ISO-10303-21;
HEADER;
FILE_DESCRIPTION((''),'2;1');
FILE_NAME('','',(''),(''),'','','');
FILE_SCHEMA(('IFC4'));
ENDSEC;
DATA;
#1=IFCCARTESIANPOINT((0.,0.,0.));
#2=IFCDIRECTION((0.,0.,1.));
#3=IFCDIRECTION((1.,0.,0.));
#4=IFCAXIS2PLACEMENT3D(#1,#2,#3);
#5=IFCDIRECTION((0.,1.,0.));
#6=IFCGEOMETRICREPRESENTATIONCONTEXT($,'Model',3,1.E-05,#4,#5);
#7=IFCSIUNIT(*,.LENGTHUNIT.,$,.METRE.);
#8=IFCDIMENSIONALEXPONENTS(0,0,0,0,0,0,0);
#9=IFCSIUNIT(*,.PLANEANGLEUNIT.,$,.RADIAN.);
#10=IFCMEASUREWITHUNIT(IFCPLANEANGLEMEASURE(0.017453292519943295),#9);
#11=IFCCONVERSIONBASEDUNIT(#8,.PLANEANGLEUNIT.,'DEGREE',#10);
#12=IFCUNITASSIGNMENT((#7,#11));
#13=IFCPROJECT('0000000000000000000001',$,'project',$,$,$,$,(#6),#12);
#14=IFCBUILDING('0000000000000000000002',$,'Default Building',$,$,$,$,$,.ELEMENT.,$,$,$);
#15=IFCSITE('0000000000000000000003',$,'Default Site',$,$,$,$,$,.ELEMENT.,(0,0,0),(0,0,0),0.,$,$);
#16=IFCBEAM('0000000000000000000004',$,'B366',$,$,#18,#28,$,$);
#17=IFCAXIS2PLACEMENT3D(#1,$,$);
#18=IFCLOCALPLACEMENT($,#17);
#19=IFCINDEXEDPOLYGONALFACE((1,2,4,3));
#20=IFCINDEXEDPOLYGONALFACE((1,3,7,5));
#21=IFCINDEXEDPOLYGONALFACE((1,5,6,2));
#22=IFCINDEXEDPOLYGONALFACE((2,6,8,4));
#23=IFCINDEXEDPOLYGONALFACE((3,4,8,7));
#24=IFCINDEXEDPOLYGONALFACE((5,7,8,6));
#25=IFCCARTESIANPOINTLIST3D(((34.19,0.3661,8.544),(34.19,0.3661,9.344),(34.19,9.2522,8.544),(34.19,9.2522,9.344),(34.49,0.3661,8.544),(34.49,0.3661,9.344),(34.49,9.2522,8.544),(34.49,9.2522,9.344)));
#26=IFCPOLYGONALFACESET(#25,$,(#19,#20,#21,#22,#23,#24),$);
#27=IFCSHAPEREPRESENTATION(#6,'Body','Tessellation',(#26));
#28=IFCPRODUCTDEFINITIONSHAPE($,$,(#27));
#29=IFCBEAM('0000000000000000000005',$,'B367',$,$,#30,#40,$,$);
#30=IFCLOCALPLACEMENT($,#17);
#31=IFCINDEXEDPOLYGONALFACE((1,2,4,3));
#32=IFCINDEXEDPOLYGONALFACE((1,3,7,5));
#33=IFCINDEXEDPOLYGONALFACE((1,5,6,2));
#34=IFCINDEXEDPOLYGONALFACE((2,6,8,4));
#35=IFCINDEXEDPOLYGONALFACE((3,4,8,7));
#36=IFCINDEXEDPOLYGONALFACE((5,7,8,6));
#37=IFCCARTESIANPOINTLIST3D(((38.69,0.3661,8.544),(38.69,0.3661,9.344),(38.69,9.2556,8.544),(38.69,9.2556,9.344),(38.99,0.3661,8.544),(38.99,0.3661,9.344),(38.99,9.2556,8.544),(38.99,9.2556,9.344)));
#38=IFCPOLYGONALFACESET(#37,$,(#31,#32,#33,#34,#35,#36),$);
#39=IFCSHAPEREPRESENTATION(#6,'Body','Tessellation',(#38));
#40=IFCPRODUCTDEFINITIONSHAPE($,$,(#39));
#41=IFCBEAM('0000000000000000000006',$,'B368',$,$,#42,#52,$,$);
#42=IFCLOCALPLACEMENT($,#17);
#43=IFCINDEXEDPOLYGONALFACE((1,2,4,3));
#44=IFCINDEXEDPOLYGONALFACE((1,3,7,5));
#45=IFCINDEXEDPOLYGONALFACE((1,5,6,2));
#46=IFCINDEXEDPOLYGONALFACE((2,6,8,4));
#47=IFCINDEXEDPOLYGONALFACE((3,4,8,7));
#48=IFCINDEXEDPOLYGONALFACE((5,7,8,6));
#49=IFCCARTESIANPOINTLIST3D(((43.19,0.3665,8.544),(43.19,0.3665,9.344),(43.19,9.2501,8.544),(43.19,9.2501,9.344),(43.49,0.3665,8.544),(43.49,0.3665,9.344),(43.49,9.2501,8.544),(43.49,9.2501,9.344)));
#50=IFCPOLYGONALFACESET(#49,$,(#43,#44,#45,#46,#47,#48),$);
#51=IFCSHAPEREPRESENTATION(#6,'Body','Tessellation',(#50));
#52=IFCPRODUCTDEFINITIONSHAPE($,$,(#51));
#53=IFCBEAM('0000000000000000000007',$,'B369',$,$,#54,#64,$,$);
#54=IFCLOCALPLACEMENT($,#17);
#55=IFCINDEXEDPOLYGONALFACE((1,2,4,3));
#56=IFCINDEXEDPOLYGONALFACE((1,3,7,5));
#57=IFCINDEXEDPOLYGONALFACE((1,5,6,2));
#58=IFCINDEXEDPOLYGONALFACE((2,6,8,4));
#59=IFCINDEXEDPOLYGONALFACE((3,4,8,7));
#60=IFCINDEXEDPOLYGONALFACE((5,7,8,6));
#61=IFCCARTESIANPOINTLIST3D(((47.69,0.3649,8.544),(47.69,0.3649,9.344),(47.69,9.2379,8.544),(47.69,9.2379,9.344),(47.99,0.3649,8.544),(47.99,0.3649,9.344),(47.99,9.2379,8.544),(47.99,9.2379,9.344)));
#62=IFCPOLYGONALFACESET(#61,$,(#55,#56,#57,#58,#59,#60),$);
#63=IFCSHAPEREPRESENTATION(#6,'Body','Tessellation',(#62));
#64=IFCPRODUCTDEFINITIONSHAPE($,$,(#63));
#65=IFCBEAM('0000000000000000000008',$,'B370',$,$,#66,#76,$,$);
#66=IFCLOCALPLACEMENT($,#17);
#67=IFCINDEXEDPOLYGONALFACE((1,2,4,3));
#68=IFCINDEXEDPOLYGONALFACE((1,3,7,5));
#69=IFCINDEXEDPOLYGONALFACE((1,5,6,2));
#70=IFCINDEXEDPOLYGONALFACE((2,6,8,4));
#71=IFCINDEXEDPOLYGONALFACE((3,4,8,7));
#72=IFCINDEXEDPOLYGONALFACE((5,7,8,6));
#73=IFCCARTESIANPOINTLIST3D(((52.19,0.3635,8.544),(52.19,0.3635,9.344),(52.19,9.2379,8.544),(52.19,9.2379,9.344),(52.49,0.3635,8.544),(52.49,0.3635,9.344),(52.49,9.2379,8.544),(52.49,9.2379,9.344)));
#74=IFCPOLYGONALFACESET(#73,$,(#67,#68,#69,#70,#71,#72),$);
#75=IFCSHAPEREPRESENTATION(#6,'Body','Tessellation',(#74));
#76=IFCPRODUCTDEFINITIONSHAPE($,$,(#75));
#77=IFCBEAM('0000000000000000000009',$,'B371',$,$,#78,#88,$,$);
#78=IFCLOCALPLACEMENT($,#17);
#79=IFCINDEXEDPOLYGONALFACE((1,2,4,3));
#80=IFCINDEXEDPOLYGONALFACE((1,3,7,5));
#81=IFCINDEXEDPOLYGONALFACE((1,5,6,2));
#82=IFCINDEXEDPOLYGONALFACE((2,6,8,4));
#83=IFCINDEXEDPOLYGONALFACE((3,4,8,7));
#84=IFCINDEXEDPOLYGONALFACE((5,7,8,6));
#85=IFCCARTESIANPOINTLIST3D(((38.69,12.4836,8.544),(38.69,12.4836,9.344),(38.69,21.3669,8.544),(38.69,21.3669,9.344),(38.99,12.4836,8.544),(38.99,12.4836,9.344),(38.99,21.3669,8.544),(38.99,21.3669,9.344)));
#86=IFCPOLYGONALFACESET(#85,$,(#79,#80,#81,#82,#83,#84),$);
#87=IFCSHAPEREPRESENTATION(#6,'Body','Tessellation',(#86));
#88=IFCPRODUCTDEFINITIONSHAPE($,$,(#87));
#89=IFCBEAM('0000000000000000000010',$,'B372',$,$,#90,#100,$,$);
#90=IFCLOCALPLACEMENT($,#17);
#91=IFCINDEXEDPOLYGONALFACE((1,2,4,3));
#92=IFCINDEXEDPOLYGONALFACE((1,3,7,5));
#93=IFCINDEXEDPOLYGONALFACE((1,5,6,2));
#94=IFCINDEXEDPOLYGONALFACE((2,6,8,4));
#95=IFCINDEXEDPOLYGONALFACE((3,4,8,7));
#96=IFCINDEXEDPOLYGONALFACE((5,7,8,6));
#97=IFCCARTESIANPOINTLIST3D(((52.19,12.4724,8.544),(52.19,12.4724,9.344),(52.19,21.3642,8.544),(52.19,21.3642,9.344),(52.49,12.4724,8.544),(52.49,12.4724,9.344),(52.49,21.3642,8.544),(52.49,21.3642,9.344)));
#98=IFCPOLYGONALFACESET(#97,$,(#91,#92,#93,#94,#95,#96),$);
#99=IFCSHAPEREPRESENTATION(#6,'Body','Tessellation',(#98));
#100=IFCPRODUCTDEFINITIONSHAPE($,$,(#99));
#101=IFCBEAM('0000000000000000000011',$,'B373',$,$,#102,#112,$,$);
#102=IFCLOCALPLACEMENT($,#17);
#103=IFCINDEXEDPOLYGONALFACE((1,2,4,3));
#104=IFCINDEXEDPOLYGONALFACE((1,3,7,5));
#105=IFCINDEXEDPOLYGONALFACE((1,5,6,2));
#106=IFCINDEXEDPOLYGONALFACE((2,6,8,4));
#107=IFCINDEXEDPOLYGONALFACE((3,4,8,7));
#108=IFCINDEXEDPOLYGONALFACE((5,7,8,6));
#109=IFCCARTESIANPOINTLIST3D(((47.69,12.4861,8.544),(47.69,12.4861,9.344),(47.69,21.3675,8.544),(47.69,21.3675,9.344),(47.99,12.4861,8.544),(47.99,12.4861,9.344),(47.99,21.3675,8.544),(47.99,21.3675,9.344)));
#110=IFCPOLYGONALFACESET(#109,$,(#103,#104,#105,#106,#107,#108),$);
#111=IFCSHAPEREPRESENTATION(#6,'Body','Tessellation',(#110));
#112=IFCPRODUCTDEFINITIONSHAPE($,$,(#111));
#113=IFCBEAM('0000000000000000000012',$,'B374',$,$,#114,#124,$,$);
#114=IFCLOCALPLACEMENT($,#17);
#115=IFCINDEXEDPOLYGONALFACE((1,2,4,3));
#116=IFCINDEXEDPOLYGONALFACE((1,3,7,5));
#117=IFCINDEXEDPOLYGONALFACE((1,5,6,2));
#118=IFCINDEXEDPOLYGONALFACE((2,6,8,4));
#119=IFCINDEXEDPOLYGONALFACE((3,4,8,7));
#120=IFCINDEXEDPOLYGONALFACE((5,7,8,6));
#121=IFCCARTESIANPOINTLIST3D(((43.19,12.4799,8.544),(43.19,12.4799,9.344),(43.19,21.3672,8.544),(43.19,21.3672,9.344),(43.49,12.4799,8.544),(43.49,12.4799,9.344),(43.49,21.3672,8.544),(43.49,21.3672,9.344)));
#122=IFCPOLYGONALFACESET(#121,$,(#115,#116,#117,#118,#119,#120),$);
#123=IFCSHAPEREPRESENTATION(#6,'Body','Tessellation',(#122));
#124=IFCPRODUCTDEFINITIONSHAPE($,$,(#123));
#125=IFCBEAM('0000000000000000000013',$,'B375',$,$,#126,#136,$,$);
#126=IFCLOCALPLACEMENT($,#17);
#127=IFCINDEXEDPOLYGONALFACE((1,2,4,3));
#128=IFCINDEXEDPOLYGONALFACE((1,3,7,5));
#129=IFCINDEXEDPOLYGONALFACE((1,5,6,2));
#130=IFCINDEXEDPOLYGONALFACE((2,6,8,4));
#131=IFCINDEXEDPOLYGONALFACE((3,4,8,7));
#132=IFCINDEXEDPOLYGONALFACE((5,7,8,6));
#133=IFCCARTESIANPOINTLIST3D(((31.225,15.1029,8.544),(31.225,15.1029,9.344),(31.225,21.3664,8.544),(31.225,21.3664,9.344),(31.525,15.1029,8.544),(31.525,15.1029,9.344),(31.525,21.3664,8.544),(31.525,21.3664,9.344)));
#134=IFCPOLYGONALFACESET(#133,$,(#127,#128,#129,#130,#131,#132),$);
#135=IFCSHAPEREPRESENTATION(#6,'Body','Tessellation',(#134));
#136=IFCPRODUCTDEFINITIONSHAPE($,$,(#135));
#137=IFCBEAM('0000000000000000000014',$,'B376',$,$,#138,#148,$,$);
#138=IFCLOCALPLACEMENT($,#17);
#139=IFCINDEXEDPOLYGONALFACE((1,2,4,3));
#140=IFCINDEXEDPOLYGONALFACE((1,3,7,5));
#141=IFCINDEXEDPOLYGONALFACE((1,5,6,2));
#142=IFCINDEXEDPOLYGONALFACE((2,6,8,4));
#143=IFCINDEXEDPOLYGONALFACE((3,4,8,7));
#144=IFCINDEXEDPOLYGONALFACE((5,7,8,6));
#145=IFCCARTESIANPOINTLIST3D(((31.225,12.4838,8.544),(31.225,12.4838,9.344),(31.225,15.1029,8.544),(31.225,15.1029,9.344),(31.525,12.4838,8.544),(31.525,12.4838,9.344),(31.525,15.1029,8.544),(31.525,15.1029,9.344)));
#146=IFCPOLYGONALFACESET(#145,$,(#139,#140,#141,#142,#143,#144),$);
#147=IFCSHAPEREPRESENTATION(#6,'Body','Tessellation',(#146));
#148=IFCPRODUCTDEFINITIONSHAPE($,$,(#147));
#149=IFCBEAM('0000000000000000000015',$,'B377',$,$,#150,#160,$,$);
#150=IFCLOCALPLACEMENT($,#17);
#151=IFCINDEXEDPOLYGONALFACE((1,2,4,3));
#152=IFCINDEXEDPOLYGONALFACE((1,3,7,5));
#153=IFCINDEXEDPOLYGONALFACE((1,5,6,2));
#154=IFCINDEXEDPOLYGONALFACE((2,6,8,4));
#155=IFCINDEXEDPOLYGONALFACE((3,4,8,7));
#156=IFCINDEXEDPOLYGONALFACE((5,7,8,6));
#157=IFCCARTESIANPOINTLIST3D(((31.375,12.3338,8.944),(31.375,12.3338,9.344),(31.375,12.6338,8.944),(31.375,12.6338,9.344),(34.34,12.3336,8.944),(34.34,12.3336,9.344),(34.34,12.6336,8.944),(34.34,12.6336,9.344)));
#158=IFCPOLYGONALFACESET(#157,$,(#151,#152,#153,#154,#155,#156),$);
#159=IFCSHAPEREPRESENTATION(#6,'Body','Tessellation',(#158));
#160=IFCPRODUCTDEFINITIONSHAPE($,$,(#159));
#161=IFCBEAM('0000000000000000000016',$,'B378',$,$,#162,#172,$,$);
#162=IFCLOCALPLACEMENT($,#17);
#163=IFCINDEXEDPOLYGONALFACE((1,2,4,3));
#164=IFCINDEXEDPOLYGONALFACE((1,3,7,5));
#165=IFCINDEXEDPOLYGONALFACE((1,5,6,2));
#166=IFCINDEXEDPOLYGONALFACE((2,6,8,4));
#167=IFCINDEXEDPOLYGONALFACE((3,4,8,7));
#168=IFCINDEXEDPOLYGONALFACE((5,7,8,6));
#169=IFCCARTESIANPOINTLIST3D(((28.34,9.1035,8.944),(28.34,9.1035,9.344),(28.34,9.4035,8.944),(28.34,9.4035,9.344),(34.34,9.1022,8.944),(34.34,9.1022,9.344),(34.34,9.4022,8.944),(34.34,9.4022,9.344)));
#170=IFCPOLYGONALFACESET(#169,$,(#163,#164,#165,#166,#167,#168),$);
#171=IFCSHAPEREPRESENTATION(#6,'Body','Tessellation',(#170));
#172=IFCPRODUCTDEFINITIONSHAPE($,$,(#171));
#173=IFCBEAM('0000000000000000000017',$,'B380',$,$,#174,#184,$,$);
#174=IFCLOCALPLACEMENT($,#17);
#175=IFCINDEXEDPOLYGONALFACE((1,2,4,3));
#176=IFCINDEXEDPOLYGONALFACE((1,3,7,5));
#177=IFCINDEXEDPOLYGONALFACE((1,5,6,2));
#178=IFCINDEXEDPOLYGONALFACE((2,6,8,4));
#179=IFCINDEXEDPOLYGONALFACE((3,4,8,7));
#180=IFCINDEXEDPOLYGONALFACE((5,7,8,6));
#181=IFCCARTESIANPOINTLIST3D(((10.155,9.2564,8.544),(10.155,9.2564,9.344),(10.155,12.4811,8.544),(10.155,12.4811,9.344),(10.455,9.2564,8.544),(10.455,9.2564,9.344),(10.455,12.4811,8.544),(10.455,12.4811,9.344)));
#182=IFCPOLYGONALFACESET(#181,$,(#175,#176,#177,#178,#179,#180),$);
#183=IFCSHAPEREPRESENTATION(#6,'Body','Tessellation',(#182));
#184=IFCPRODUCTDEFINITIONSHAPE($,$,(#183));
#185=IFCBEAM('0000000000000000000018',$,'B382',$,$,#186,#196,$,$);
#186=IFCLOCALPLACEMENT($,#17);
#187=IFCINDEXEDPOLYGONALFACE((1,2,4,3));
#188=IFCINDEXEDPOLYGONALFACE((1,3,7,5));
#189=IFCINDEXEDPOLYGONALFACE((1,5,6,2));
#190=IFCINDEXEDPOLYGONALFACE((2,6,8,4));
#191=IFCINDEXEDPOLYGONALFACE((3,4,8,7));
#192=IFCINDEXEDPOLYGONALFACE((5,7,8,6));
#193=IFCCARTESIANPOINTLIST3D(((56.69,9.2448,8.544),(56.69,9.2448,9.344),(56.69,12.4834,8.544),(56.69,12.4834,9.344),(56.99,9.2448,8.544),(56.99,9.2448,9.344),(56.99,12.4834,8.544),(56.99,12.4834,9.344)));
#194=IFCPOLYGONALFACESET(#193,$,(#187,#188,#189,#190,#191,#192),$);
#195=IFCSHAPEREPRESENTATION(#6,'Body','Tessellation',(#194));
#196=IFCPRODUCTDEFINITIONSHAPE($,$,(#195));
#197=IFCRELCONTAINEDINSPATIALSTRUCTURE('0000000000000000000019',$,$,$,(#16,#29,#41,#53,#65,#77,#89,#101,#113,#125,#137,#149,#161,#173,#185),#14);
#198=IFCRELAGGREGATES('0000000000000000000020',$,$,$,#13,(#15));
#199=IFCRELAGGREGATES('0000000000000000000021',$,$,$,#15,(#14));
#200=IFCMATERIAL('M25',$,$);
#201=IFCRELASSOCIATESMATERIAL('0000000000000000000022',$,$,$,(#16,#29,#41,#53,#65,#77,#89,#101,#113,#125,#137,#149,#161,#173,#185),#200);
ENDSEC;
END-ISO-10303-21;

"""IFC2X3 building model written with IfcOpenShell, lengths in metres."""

from ifc_helpers import new_model, entity, si_unit, converted_unit, direction, frame, frame_2d, origin_with_axes, place, context, project, spatial, rectangle, extrude, material, element, save


model = new_model("IFC2X3")

# Units and contexts
model_context = context("Model", 3, precision=1e-05, world=origin_with_axes(), true_north=direction((0.0, 1.0, 0.0)))
ifc_project = project(units=[si_unit("LENGTHUNIT", "METRE"), converted_unit("PLANEANGLEUNIT", "DEGREE", entity("IfcPlaneAngleMeasure", 0.017453292519943295), si_unit("PLANEANGLEUNIT", "RADIAN"), dimensions=[0, 0, 0, 0, 0, 0, 0])], contexts=[model_context])

# Site, building
site = spatial("IfcSite", under=ifc_project, Name="Default Site", CompositionType="ELEMENT", RefLatitude=(0, 0, 0), RefLongitude=(0, 0, 0), RefElevation=0.0)
building = spatial("IfcBuilding", under=site, Name="Default Building", CompositionType="ELEMENT")

# Beams
ifc_material = material(Name="M25")
placement = place(None, origin_with_axes())
element("IfcBeam", 1, at=placement, inside=building, material=ifc_material, Name="B366", context=model_context, shape_type="SweptSolid", body=[
    extrude(rectangle(XDim=0.3, YDim=0.8, at=frame_2d((0.0, 0.0), x_axis=(0.0, 1.0, 0.0))), frame((34.34, 0.3661, 8.944), z_axis=(0.0, 1.0, 0.0), x_axis=(0.0, 0.0, -1.0)), (0.0, 0.0, 1.0), 8.8861),
])
element("IfcBeam", 2, at=placement, inside=building, material=ifc_material, Name="B367", context=model_context, shape_type="SweptSolid", body=[
    extrude(rectangle(XDim=0.3, YDim=0.8, at=frame_2d((0.0, 0.0), x_axis=(0.0, 1.0, 0.0))), frame((38.84, 0.3661, 8.944), z_axis=(0.0, 1.0, 0.0), x_axis=(0.0, 0.0, -1.0)), (0.0, 0.0, 1.0), 8.8895),
])
element("IfcBeam", 3, at=placement, inside=building, material=ifc_material, Name="B368", context=model_context, shape_type="SweptSolid", body=[
    extrude(rectangle(XDim=0.3, YDim=0.8, at=frame_2d((0.0, 0.0), x_axis=(0.0, 1.0, 0.0))), frame((43.34, 0.3665, 8.944), z_axis=(0.0, 1.0, 0.0), x_axis=(0.0, 0.0, -1.0)), (0.0, 0.0, 1.0), 8.8836),
])
element("IfcBeam", 4, at=placement, inside=building, material=ifc_material, Name="B369", context=model_context, shape_type="SweptSolid", body=[
    extrude(rectangle(XDim=0.3, YDim=0.8, at=frame_2d((0.0, 0.0), x_axis=(0.0, 1.0, 0.0))), frame((47.84, 0.3649, 8.944), z_axis=(0.0, 1.0, 0.0), x_axis=(0.0, 0.0, -1.0)), (0.0, 0.0, 1.0), 8.873),
])
element("IfcBeam", 5, at=placement, inside=building, material=ifc_material, Name="B370", context=model_context, shape_type="SweptSolid", body=[
    extrude(rectangle(XDim=0.3, YDim=0.8, at=frame_2d((0.0, 0.0), x_axis=(0.0, 1.0, 0.0))), frame((52.34, 0.3635, 8.944), z_axis=(0.0, 1.0, 0.0), x_axis=(0.0, 0.0, -1.0)), (0.0, 0.0, 1.0), 8.8744),
])
element("IfcBeam", 6, at=placement, inside=building, material=ifc_material, Name="B371", context=model_context, shape_type="SweptSolid", body=[
    extrude(rectangle(XDim=0.3, YDim=0.8, at=frame_2d((0.0, 0.0), x_axis=(0.0, 1.0, 0.0))), frame((38.84, 21.3669, 8.944), z_axis=(0.0, -1.0, 0.0), x_axis=(0.0, 0.0, -1.0)), (0.0, 0.0, 1.0), 8.8833),
])
element("IfcBeam", 7, at=placement, inside=building, material=ifc_material, Name="B372", context=model_context, shape_type="SweptSolid", body=[
    extrude(rectangle(XDim=0.3, YDim=0.8, at=frame_2d((0.0, 0.0), x_axis=(0.0, 1.0, 0.0))), frame((52.34, 12.4724, 8.944), z_axis=(0.0, 1.0, 0.0), x_axis=(0.0, 0.0, -1.0)), (0.0, 0.0, 1.0), 8.8918),
])
element("IfcBeam", 8, at=placement, inside=building, material=ifc_material, Name="B373", context=model_context, shape_type="SweptSolid", body=[
    extrude(rectangle(XDim=0.3, YDim=0.8, at=frame_2d((0.0, 0.0), x_axis=(0.0, 1.0, 0.0))), frame((47.84, 12.4861, 8.944), z_axis=(0.0, 1.0, 0.0), x_axis=(0.0, 0.0, -1.0)), (0.0, 0.0, 1.0), 8.8814),
])
element("IfcBeam", 9, at=placement, inside=building, material=ifc_material, Name="B374", context=model_context, shape_type="SweptSolid", body=[
    extrude(rectangle(XDim=0.3, YDim=0.8, at=frame_2d((0.0, 0.0), x_axis=(0.0, 1.0, 0.0))), frame((43.34, 21.3672, 8.944), z_axis=(0.0, -1.0, 0.0), x_axis=(0.0, 0.0, -1.0)), (0.0, 0.0, 1.0), 8.8873),
])
element("IfcBeam", 10, at=placement, inside=building, material=ifc_material, Name="B375", context=model_context, shape_type="SweptSolid", body=[
    extrude(rectangle(XDim=0.3, YDim=0.8, at=frame_2d((0.0, 0.0), x_axis=(0.0, 1.0, 0.0))), frame((31.375, 21.3664, 8.944), z_axis=(0.0, -1.0, 0.0), x_axis=(0.0, 0.0, -1.0)), (0.0, 0.0, 1.0), 6.2635),
])
element("IfcBeam", 11, at=placement, inside=building, material=ifc_material, Name="B376", context=model_context, shape_type="SweptSolid", body=[
    extrude(rectangle(XDim=0.3, YDim=0.8, at=frame_2d((0.0, 0.0), x_axis=(0.0, 1.0, 0.0))), frame((31.375, 15.1029, 8.944), z_axis=(0.0, -1.0, 0.0), x_axis=(0.0, 0.0, -1.0)), (0.0, 0.0, 1.0), 2.6191),
])
element("IfcBeam", 12, at=placement, inside=building, material=ifc_material, Name="B377", context=model_context, shape_type="SweptSolid", body=[
    extrude(rectangle(XDim=0.3, YDim=0.4, at=frame_2d((0.0, 0.0), x_axis=(0.0, 1.0, 0.0))), frame((31.375, 12.4838, 9.144), z_axis=(1.0, -0.000067, 0.0), x_axis=(0.0, 0.0, -1.0)), (0.0, 0.0, 1.0), 2.965),
])
element("IfcBeam", 13, at=placement, inside=building, material=ifc_material, Name="B378", context=model_context, shape_type="SweptSolid", body=[
    extrude(rectangle(XDim=0.3, YDim=0.4, at=frame_2d((0.0, 0.0), x_axis=(0.0, 1.0, 0.0))), frame((28.34, 9.2535, 9.144), z_axis=(1.0, -0.000213, 0.0), x_axis=(0.0, 0.0, -1.0)), (0.0, 0.0, 1.0), 6.0),
])
element("IfcBeam", 14, at=placement, inside=building, material=ifc_material, Name="B380", context=model_context, shape_type="SweptSolid", body=[
    extrude(rectangle(XDim=0.3, YDim=0.8, at=frame_2d((0.0, 0.0), x_axis=(0.0, 1.0, 0.0))), frame((10.305, 12.4811, 8.944), z_axis=(0.0, -1.0, 0.0), x_axis=(0.0, 0.0, -1.0)), (0.0, 0.0, 1.0), 3.2247),
])
element("IfcBeam", 15, at=placement, inside=building, material=ifc_material, Name="B382", context=model_context, shape_type="SweptSolid", body=[
    extrude(rectangle(XDim=0.3, YDim=0.8, at=frame_2d((0.0, 0.0), x_axis=(0.0, 1.0, 0.0))), frame((56.84, 12.4834, 8.944), z_axis=(0.0, -1.0, 0.0), x_axis=(0.0, 0.0, -1.0)), (0.0, 0.0, 1.0), 3.2386),
])

save(model, "model.ifc")
